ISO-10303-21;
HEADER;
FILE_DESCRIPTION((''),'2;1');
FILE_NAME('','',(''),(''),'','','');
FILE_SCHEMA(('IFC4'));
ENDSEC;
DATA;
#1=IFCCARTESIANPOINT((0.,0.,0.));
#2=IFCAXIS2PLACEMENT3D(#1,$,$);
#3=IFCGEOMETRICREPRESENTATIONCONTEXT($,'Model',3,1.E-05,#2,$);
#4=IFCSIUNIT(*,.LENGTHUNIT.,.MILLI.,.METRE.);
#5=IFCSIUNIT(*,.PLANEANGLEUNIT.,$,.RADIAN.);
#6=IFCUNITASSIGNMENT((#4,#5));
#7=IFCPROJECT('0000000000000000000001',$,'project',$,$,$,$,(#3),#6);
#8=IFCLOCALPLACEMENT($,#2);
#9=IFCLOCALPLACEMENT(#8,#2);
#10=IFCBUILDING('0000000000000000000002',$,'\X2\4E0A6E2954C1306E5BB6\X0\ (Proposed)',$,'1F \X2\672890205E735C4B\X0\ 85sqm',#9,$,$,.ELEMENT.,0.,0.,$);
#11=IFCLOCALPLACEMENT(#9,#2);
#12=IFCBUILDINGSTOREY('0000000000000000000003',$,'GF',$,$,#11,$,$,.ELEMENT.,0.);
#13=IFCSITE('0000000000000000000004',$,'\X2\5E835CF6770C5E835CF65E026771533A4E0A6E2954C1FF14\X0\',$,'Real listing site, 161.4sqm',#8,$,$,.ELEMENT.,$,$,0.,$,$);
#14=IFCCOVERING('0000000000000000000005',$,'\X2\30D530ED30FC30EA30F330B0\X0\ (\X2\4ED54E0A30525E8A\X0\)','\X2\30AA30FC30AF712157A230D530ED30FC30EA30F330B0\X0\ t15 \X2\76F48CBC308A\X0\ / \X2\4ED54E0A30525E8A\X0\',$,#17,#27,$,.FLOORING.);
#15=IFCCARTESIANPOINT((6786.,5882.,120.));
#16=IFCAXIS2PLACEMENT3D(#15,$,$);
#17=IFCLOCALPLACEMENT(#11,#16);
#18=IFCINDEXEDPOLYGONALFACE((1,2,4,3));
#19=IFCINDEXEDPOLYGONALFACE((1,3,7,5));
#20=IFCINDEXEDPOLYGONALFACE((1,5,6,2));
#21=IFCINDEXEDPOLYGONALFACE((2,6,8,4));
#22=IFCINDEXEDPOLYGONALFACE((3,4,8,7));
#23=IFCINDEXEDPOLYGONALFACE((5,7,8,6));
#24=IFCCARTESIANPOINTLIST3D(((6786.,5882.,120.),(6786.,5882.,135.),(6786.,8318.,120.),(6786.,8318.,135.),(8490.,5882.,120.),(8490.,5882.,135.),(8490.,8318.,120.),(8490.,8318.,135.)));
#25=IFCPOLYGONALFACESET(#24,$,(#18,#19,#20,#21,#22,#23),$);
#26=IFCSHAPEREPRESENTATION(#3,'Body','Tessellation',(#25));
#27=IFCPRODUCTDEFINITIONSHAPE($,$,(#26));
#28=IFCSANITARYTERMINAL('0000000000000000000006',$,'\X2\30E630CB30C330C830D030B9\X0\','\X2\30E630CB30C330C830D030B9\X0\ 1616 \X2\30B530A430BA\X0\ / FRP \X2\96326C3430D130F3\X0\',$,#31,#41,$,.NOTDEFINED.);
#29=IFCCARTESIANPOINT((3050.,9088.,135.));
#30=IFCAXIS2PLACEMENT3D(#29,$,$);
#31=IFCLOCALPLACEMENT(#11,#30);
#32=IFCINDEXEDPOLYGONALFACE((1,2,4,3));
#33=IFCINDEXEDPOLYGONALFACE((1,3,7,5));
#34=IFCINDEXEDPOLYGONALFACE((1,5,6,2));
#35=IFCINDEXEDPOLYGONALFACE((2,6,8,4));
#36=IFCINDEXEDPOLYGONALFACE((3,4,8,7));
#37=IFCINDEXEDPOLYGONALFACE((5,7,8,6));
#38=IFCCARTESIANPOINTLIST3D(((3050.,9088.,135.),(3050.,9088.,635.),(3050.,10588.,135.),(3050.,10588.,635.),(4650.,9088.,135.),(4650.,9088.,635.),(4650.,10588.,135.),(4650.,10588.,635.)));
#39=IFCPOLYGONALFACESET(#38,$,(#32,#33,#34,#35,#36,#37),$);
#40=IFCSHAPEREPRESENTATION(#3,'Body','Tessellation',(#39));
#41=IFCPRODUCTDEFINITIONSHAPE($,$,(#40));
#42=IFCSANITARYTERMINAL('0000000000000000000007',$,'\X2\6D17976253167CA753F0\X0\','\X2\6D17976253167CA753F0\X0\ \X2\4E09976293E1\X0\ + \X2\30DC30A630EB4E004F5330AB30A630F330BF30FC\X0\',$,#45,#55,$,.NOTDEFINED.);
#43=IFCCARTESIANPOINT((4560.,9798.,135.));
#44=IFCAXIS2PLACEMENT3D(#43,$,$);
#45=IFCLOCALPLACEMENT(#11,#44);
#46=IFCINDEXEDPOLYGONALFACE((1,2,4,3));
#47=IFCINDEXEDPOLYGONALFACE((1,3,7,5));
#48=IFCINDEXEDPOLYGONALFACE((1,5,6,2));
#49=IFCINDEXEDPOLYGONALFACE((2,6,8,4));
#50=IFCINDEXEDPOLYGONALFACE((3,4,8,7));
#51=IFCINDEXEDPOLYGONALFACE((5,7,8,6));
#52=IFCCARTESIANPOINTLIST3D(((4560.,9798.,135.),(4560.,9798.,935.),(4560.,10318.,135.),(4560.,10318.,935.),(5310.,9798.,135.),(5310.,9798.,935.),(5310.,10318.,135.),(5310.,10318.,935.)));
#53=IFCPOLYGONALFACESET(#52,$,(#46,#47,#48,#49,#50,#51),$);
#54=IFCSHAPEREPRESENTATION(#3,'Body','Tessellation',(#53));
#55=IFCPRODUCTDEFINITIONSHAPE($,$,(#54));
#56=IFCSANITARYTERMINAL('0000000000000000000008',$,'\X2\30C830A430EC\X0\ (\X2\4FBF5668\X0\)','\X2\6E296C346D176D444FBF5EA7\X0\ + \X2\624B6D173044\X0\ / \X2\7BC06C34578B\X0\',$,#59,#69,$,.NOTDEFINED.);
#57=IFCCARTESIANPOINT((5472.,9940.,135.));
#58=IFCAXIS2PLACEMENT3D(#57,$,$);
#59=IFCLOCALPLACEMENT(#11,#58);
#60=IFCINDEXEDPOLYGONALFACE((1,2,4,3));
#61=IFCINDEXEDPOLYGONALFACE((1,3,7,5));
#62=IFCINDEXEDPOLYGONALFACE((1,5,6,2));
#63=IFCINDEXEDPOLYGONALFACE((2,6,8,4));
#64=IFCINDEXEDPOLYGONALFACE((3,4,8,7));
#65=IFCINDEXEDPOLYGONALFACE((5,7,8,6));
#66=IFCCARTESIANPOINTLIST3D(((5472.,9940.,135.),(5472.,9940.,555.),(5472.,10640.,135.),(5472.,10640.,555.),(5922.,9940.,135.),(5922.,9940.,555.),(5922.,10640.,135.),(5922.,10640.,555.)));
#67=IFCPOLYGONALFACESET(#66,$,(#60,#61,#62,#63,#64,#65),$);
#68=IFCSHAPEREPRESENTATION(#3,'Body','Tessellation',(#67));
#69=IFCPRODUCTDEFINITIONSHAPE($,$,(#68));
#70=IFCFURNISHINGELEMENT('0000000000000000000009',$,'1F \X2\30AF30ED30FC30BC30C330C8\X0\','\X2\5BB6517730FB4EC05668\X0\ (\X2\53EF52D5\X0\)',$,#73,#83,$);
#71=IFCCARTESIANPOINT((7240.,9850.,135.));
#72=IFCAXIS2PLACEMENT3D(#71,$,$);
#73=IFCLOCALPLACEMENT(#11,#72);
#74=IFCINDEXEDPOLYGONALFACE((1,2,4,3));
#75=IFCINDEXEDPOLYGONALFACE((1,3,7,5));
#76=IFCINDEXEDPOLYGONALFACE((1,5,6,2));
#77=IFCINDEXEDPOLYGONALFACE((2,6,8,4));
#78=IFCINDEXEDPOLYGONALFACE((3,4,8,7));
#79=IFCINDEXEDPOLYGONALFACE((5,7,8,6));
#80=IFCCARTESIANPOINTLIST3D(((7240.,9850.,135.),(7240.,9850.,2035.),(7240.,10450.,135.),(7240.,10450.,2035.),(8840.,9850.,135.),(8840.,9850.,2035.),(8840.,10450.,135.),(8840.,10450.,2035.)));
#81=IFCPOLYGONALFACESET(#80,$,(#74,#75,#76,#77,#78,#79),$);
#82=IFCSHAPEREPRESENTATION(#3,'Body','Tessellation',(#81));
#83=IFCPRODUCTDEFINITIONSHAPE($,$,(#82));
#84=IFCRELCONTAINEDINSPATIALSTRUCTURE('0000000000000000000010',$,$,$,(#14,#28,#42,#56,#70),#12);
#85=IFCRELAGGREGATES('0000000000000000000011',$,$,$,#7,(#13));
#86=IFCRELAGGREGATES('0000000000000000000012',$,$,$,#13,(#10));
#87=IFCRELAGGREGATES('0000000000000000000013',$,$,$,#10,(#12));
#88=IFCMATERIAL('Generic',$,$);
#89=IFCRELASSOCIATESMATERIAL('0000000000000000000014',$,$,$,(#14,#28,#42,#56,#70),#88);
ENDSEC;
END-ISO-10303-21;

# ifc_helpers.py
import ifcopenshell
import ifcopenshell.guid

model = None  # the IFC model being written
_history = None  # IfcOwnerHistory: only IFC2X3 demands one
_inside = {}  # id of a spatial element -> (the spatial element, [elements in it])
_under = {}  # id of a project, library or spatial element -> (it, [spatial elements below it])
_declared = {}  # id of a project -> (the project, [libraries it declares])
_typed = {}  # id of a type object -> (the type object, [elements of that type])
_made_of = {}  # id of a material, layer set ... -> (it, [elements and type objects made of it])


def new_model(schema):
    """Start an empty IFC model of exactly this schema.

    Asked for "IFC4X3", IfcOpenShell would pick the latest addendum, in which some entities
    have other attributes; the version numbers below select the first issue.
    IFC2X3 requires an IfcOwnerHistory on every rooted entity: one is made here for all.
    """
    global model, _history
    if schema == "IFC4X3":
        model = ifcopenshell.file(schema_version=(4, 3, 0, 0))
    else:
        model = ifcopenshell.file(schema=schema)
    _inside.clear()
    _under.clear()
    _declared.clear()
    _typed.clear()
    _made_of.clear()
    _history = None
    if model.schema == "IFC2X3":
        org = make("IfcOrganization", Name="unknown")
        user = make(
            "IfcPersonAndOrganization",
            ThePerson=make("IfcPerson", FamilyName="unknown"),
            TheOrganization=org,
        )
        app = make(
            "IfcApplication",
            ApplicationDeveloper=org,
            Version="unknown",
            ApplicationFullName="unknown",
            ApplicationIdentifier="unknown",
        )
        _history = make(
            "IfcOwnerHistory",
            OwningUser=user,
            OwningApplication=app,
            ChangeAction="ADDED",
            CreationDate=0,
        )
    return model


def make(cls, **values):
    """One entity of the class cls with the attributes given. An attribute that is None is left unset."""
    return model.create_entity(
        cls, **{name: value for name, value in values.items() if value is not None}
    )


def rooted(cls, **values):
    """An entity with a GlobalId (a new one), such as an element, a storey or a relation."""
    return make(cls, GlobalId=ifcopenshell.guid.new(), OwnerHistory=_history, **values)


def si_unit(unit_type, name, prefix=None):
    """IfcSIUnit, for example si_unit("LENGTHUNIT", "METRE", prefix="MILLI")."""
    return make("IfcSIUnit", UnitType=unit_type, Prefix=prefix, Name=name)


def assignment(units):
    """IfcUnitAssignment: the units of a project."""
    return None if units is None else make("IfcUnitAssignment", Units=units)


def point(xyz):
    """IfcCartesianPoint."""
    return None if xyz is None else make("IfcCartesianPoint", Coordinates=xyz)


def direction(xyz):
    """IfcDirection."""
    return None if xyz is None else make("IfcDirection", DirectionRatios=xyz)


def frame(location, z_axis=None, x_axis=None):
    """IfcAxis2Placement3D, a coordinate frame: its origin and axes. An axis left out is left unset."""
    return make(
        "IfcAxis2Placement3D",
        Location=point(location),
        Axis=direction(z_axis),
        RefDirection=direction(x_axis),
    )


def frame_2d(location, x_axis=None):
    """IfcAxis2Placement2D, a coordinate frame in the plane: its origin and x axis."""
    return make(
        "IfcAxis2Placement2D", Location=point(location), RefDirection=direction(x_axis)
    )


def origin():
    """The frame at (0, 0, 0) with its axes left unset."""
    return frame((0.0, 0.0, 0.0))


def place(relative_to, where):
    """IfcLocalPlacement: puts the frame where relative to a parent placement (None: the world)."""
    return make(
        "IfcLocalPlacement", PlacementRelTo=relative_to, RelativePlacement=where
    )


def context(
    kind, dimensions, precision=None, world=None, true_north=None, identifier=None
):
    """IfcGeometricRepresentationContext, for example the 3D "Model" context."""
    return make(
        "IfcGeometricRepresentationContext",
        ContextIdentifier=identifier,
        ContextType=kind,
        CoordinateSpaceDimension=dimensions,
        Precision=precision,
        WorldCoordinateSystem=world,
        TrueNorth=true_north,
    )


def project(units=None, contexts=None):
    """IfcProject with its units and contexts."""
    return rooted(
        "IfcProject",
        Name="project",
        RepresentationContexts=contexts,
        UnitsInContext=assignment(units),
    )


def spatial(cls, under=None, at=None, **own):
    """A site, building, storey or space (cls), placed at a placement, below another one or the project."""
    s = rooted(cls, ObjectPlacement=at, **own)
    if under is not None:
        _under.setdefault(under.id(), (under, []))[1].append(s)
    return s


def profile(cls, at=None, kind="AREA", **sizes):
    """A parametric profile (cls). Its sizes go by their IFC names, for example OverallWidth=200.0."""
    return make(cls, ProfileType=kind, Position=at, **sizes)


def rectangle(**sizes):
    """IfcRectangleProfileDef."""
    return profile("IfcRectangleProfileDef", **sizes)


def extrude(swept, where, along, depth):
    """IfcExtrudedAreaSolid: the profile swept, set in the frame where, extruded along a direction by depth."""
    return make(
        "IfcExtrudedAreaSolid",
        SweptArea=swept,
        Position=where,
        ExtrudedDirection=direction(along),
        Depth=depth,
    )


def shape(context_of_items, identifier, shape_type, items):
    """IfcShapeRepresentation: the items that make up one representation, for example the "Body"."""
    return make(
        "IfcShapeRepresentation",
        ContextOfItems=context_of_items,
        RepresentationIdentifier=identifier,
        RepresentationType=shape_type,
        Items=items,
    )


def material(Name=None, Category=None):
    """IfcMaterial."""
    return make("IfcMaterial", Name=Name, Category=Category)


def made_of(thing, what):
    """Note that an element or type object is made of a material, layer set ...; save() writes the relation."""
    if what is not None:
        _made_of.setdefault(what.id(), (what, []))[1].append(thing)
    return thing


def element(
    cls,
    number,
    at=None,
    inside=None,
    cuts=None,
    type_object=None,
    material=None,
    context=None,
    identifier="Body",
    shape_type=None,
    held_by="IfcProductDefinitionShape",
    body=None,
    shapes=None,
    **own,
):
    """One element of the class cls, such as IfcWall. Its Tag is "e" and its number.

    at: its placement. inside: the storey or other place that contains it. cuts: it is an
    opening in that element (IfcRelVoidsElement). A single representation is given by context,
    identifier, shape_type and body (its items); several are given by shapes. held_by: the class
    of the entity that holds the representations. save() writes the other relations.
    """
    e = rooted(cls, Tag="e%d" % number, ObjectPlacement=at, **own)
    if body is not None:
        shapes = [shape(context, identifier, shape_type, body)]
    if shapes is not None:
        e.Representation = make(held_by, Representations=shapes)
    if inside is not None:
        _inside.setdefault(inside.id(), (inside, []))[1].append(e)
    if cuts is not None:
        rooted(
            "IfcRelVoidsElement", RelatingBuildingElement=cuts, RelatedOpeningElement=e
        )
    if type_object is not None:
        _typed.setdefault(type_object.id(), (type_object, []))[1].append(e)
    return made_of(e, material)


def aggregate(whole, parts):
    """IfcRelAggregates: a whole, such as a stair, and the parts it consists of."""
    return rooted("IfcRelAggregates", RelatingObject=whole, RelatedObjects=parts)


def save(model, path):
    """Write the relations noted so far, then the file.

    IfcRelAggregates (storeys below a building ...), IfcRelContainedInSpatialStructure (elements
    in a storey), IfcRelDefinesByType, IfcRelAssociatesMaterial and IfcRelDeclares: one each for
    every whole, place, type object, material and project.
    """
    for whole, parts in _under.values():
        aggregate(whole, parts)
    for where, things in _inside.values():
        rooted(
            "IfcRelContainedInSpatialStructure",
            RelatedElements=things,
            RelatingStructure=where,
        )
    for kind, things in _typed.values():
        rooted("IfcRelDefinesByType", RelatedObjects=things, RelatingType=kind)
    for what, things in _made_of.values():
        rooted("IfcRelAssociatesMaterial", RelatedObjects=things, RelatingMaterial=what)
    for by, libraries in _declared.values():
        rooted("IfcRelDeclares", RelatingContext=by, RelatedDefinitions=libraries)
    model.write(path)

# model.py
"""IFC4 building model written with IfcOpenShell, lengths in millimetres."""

from ifc_helpers import new_model, si_unit, frame, frame_2d, origin, place, context, project, spatial, rectangle, extrude, material, element, save


model = new_model("IFC4")

# Units and contexts
model_context = context("Model", 3, precision=1e-05, world=origin())
ifc_project = project(units=[si_unit("LENGTHUNIT", "METRE", prefix="MILLI"), si_unit("PLANEANGLEUNIT", "RADIAN")], contexts=[model_context])

# Site, building, storey
site_placement = place(None, origin())
site = spatial("IfcSite", under=ifc_project, at=site_placement, Name="広島県広島市東区上温品４", ObjectType="Real listing site, 161.4sqm", CompositionType="ELEMENT", RefElevation=0.0)
building_placement = place(site_placement, origin())
building = spatial("IfcBuilding", under=site, at=building_placement, Name="上温品の家 (Proposed)", ObjectType="1F 木造平屋 85sqm", CompositionType="ELEMENT", ElevationOfRefHeight=0.0, ElevationOfTerrain=0.0)
storey_placement = place(building_placement, origin())
storey = spatial("IfcBuildingStorey", under=building, at=storey_placement, Name="GF", CompositionType="ELEMENT", Elevation=0.0)

# Covering
ifc_material_1 = material(Name="Generic")
covering_1_placement = place(storey_placement, frame((6786.0, 5882.0, 120.0)))
element("IfcCovering", 1, at=covering_1_placement, inside=storey, material=ifc_material_1, Name="フローリング (仕上げ床)", Description="オーク無垢フローリング t15 直貼り / 仕上げ床", PredefinedType="FLOORING", context=model_context, shape_type="SweptSolid", body=[
    extrude(rectangle(XDim=1704.0, YDim=2436.0, at=frame_2d((852.0, 1218.0))), frame((6786.0, 5882.0, 120.0)), (0.0, 0.0, 1.0), 15.0),
])

# Sanitary terminals
sanitary_terminal_1_placement = place(storey_placement, frame((3050.0, 9088.0, 135.0)))
element("IfcSanitaryTerminal", 2, at=sanitary_terminal_1_placement, inside=storey, material=ifc_material_1, Name="ユニットバス", Description="ユニットバス 1616 サイズ / FRP 防水パン", PredefinedType="NOTDEFINED", context=model_context, shape_type="SweptSolid", body=[
    extrude(rectangle(XDim=1600.0, YDim=1500.0, at=frame_2d((800.0, 750.0))), frame((3050.0, 9088.0, 135.0)), (0.0, 0.0, 1.0), 500.0),
])
sanitary_terminal_2_placement = place(storey_placement, frame((4560.0, 9798.0, 135.0)))
element("IfcSanitaryTerminal", 3, at=sanitary_terminal_2_placement, inside=storey, material=ifc_material_1, Name="洗面化粧台", Description="洗面化粧台 三面鏡 + ボウル一体カウンター", PredefinedType="NOTDEFINED", context=model_context, shape_type="SweptSolid", body=[
    extrude(rectangle(XDim=750.0, YDim=520.0, at=frame_2d((375.0, 260.0))), frame((4560.0, 9798.0, 135.0)), (0.0, 0.0, 1.0), 800.0),
])
sanitary_terminal_3_placement = place(storey_placement, frame((5472.0, 9940.0, 135.0)))
element("IfcSanitaryTerminal", 4, at=sanitary_terminal_3_placement, inside=storey, material=ifc_material_1, Name="トイレ (便器)", Description="温水洗浄便座 + 手洗い / 節水型", PredefinedType="NOTDEFINED", context=model_context, shape_type="SweptSolid", body=[
    extrude(rectangle(XDim=450.0, YDim=700.0, at=frame_2d((225.0, 350.0))), frame((5472.0, 9940.0, 135.0)), (0.0, 0.0, 1.0), 420.0),
])

# Furnishing element
furnishing_placement = place(storey_placement, frame((7240.0, 9850.0, 135.0)))
element("IfcFurnishingElement", 5, at=furnishing_placement, inside=storey, material=ifc_material_1, Name="1F クローゼット", Description="家具・什器 (可動)", context=model_context, shape_type="SweptSolid", body=[
    extrude(rectangle(XDim=1600.0, YDim=600.0, at=frame_2d((800.0, 300.0))), frame((7240.0, 9850.0, 135.0)), (0.0, 0.0, 1.0), 1900.0),
])

save(model, "model.ifc")
